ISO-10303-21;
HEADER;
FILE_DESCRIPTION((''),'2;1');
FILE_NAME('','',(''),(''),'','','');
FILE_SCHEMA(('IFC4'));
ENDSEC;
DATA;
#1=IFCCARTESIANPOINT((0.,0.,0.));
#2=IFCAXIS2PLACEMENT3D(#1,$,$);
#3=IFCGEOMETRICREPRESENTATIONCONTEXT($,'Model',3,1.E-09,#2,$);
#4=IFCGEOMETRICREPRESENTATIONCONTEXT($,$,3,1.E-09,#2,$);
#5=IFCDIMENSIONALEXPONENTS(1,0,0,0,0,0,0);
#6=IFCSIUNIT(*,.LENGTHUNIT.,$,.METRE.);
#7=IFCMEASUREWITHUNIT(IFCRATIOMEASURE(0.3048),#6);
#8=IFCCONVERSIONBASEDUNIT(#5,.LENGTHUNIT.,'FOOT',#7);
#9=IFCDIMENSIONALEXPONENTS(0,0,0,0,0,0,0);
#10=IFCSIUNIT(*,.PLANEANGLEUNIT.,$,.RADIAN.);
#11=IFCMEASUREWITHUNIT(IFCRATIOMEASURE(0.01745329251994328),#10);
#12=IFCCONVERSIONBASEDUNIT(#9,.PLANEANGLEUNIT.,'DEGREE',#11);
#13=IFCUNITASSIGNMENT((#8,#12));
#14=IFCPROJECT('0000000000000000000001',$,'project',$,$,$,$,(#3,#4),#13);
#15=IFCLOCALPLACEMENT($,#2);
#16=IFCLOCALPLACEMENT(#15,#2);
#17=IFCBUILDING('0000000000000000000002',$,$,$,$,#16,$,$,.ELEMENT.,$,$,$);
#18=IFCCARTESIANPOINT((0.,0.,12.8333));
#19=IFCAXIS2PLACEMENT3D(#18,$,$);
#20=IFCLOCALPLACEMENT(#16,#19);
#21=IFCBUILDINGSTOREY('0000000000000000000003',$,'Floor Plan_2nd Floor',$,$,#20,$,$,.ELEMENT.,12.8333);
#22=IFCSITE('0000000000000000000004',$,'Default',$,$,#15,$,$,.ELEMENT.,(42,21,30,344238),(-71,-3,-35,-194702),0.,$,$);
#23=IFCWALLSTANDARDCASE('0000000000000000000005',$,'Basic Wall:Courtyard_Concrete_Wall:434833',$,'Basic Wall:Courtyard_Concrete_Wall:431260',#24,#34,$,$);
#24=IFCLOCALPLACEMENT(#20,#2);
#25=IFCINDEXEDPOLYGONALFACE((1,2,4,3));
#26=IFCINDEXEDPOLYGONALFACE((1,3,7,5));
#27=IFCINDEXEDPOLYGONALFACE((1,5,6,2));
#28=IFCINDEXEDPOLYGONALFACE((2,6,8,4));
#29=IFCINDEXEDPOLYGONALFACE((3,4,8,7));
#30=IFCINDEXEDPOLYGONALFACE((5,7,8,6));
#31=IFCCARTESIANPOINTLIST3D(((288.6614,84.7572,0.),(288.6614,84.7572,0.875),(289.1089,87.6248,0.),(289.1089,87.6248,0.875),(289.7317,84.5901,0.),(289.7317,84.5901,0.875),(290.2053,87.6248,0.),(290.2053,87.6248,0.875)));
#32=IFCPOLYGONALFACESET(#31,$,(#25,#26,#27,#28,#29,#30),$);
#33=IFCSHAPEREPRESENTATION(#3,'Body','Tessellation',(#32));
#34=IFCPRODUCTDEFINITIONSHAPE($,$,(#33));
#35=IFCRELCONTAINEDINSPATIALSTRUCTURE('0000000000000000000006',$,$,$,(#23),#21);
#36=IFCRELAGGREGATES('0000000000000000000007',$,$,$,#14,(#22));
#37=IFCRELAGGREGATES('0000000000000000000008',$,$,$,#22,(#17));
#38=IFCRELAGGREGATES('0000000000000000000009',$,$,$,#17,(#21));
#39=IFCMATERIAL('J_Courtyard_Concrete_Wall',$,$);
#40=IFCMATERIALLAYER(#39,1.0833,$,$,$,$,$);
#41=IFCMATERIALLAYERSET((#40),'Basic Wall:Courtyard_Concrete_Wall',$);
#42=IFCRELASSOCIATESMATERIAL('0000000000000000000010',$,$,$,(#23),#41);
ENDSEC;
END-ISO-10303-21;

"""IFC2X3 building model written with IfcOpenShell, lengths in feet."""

from ifc_helpers import new_model, entity, si_unit, converted_unit, frame, origin, place, context, project, spatial, polyline, outline, extrude, clip, halfspace, material, layer, layer_set, layer_usage, element, save


model = new_model("IFC2X3")

# Units and contexts
model_context = context("Model", 3, precision=1e-09, world=origin())
context_of_model = context(None, 3, precision=1e-09, world=origin())
ifc_project = project(units=[converted_unit("LENGTHUNIT", "FOOT", entity("IfcRatioMeasure", 0.3048), si_unit("LENGTHUNIT", "METRE"), dimensions=[1, 0, 0, 0, 0, 0, 0]), converted_unit("PLANEANGLEUNIT", "DEGREE", entity("IfcRatioMeasure", 0.01745329251994328), si_unit("PLANEANGLEUNIT", "RADIAN"), dimensions=[0, 0, 0, 0, 0, 0, 0])], contexts=[model_context, context_of_model])

# Site, building, storey
site_placement = place(None, origin())
site = spatial("IfcSite", under=ifc_project, at=site_placement, Name="Default", CompositionType="ELEMENT", RefLatitude=(42, 21, 30, 344238), RefLongitude=(-71, -3, -35, -194702), RefElevation=0.0)
building_placement = place(site_placement, origin())
building = spatial("IfcBuilding", under=site, at=building_placement, CompositionType="ELEMENT")
storey_placement = place(building_placement, frame((0.0, 0.0, 12.8333)))
storey = spatial("IfcBuildingStorey", under=building, at=storey_placement, Name="Floor Plan_2nd Floor", CompositionType="ELEMENT", Elevation=12.8333)

# Wall
ifc_material_1 = material(Name="J_Courtyard_Concrete_Wall")
ifc_layer_1 = layer(ifc_material_1, 1.0833)
ifc_layer_set_1 = layer_set([ifc_layer_1], Name="Basic Wall:Courtyard_Concrete_Wall")
ifc_layer_usage_1 = layer_usage(ifc_layer_set_1, "AXIS2", "NEGATIVE", 0.5417)
wall_1_placement = place(storey_placement, frame((289.6701, 87.7083, 0.0), z_axis=(0.0, 0.0, 1.0), x_axis=(-0.154194, -0.988041, 0.0)))
element("IfcWallStandardCase", 1, at=wall_1_placement, inside=storey, material=ifc_layer_usage_1, Name="Basic Wall:Courtyard_Concrete_Wall:434833", ObjectType="Basic Wall:Courtyard_Concrete_Wall:431260", context=model_context, shape_type="Clipping", body=[
    clip(extrude(outline(polyline([(3.0714, -0.5417), (3.0714, 0.5417), (0.0, 0.5417), (0.1691, -0.5417), (3.0714, -0.5417)])), origin(), (0.0, 0.0, 1.0), 0.875), halfspace(frame((0.0, 0.0, -12.6667)), True)),
])

save(model, "model.ifc")
